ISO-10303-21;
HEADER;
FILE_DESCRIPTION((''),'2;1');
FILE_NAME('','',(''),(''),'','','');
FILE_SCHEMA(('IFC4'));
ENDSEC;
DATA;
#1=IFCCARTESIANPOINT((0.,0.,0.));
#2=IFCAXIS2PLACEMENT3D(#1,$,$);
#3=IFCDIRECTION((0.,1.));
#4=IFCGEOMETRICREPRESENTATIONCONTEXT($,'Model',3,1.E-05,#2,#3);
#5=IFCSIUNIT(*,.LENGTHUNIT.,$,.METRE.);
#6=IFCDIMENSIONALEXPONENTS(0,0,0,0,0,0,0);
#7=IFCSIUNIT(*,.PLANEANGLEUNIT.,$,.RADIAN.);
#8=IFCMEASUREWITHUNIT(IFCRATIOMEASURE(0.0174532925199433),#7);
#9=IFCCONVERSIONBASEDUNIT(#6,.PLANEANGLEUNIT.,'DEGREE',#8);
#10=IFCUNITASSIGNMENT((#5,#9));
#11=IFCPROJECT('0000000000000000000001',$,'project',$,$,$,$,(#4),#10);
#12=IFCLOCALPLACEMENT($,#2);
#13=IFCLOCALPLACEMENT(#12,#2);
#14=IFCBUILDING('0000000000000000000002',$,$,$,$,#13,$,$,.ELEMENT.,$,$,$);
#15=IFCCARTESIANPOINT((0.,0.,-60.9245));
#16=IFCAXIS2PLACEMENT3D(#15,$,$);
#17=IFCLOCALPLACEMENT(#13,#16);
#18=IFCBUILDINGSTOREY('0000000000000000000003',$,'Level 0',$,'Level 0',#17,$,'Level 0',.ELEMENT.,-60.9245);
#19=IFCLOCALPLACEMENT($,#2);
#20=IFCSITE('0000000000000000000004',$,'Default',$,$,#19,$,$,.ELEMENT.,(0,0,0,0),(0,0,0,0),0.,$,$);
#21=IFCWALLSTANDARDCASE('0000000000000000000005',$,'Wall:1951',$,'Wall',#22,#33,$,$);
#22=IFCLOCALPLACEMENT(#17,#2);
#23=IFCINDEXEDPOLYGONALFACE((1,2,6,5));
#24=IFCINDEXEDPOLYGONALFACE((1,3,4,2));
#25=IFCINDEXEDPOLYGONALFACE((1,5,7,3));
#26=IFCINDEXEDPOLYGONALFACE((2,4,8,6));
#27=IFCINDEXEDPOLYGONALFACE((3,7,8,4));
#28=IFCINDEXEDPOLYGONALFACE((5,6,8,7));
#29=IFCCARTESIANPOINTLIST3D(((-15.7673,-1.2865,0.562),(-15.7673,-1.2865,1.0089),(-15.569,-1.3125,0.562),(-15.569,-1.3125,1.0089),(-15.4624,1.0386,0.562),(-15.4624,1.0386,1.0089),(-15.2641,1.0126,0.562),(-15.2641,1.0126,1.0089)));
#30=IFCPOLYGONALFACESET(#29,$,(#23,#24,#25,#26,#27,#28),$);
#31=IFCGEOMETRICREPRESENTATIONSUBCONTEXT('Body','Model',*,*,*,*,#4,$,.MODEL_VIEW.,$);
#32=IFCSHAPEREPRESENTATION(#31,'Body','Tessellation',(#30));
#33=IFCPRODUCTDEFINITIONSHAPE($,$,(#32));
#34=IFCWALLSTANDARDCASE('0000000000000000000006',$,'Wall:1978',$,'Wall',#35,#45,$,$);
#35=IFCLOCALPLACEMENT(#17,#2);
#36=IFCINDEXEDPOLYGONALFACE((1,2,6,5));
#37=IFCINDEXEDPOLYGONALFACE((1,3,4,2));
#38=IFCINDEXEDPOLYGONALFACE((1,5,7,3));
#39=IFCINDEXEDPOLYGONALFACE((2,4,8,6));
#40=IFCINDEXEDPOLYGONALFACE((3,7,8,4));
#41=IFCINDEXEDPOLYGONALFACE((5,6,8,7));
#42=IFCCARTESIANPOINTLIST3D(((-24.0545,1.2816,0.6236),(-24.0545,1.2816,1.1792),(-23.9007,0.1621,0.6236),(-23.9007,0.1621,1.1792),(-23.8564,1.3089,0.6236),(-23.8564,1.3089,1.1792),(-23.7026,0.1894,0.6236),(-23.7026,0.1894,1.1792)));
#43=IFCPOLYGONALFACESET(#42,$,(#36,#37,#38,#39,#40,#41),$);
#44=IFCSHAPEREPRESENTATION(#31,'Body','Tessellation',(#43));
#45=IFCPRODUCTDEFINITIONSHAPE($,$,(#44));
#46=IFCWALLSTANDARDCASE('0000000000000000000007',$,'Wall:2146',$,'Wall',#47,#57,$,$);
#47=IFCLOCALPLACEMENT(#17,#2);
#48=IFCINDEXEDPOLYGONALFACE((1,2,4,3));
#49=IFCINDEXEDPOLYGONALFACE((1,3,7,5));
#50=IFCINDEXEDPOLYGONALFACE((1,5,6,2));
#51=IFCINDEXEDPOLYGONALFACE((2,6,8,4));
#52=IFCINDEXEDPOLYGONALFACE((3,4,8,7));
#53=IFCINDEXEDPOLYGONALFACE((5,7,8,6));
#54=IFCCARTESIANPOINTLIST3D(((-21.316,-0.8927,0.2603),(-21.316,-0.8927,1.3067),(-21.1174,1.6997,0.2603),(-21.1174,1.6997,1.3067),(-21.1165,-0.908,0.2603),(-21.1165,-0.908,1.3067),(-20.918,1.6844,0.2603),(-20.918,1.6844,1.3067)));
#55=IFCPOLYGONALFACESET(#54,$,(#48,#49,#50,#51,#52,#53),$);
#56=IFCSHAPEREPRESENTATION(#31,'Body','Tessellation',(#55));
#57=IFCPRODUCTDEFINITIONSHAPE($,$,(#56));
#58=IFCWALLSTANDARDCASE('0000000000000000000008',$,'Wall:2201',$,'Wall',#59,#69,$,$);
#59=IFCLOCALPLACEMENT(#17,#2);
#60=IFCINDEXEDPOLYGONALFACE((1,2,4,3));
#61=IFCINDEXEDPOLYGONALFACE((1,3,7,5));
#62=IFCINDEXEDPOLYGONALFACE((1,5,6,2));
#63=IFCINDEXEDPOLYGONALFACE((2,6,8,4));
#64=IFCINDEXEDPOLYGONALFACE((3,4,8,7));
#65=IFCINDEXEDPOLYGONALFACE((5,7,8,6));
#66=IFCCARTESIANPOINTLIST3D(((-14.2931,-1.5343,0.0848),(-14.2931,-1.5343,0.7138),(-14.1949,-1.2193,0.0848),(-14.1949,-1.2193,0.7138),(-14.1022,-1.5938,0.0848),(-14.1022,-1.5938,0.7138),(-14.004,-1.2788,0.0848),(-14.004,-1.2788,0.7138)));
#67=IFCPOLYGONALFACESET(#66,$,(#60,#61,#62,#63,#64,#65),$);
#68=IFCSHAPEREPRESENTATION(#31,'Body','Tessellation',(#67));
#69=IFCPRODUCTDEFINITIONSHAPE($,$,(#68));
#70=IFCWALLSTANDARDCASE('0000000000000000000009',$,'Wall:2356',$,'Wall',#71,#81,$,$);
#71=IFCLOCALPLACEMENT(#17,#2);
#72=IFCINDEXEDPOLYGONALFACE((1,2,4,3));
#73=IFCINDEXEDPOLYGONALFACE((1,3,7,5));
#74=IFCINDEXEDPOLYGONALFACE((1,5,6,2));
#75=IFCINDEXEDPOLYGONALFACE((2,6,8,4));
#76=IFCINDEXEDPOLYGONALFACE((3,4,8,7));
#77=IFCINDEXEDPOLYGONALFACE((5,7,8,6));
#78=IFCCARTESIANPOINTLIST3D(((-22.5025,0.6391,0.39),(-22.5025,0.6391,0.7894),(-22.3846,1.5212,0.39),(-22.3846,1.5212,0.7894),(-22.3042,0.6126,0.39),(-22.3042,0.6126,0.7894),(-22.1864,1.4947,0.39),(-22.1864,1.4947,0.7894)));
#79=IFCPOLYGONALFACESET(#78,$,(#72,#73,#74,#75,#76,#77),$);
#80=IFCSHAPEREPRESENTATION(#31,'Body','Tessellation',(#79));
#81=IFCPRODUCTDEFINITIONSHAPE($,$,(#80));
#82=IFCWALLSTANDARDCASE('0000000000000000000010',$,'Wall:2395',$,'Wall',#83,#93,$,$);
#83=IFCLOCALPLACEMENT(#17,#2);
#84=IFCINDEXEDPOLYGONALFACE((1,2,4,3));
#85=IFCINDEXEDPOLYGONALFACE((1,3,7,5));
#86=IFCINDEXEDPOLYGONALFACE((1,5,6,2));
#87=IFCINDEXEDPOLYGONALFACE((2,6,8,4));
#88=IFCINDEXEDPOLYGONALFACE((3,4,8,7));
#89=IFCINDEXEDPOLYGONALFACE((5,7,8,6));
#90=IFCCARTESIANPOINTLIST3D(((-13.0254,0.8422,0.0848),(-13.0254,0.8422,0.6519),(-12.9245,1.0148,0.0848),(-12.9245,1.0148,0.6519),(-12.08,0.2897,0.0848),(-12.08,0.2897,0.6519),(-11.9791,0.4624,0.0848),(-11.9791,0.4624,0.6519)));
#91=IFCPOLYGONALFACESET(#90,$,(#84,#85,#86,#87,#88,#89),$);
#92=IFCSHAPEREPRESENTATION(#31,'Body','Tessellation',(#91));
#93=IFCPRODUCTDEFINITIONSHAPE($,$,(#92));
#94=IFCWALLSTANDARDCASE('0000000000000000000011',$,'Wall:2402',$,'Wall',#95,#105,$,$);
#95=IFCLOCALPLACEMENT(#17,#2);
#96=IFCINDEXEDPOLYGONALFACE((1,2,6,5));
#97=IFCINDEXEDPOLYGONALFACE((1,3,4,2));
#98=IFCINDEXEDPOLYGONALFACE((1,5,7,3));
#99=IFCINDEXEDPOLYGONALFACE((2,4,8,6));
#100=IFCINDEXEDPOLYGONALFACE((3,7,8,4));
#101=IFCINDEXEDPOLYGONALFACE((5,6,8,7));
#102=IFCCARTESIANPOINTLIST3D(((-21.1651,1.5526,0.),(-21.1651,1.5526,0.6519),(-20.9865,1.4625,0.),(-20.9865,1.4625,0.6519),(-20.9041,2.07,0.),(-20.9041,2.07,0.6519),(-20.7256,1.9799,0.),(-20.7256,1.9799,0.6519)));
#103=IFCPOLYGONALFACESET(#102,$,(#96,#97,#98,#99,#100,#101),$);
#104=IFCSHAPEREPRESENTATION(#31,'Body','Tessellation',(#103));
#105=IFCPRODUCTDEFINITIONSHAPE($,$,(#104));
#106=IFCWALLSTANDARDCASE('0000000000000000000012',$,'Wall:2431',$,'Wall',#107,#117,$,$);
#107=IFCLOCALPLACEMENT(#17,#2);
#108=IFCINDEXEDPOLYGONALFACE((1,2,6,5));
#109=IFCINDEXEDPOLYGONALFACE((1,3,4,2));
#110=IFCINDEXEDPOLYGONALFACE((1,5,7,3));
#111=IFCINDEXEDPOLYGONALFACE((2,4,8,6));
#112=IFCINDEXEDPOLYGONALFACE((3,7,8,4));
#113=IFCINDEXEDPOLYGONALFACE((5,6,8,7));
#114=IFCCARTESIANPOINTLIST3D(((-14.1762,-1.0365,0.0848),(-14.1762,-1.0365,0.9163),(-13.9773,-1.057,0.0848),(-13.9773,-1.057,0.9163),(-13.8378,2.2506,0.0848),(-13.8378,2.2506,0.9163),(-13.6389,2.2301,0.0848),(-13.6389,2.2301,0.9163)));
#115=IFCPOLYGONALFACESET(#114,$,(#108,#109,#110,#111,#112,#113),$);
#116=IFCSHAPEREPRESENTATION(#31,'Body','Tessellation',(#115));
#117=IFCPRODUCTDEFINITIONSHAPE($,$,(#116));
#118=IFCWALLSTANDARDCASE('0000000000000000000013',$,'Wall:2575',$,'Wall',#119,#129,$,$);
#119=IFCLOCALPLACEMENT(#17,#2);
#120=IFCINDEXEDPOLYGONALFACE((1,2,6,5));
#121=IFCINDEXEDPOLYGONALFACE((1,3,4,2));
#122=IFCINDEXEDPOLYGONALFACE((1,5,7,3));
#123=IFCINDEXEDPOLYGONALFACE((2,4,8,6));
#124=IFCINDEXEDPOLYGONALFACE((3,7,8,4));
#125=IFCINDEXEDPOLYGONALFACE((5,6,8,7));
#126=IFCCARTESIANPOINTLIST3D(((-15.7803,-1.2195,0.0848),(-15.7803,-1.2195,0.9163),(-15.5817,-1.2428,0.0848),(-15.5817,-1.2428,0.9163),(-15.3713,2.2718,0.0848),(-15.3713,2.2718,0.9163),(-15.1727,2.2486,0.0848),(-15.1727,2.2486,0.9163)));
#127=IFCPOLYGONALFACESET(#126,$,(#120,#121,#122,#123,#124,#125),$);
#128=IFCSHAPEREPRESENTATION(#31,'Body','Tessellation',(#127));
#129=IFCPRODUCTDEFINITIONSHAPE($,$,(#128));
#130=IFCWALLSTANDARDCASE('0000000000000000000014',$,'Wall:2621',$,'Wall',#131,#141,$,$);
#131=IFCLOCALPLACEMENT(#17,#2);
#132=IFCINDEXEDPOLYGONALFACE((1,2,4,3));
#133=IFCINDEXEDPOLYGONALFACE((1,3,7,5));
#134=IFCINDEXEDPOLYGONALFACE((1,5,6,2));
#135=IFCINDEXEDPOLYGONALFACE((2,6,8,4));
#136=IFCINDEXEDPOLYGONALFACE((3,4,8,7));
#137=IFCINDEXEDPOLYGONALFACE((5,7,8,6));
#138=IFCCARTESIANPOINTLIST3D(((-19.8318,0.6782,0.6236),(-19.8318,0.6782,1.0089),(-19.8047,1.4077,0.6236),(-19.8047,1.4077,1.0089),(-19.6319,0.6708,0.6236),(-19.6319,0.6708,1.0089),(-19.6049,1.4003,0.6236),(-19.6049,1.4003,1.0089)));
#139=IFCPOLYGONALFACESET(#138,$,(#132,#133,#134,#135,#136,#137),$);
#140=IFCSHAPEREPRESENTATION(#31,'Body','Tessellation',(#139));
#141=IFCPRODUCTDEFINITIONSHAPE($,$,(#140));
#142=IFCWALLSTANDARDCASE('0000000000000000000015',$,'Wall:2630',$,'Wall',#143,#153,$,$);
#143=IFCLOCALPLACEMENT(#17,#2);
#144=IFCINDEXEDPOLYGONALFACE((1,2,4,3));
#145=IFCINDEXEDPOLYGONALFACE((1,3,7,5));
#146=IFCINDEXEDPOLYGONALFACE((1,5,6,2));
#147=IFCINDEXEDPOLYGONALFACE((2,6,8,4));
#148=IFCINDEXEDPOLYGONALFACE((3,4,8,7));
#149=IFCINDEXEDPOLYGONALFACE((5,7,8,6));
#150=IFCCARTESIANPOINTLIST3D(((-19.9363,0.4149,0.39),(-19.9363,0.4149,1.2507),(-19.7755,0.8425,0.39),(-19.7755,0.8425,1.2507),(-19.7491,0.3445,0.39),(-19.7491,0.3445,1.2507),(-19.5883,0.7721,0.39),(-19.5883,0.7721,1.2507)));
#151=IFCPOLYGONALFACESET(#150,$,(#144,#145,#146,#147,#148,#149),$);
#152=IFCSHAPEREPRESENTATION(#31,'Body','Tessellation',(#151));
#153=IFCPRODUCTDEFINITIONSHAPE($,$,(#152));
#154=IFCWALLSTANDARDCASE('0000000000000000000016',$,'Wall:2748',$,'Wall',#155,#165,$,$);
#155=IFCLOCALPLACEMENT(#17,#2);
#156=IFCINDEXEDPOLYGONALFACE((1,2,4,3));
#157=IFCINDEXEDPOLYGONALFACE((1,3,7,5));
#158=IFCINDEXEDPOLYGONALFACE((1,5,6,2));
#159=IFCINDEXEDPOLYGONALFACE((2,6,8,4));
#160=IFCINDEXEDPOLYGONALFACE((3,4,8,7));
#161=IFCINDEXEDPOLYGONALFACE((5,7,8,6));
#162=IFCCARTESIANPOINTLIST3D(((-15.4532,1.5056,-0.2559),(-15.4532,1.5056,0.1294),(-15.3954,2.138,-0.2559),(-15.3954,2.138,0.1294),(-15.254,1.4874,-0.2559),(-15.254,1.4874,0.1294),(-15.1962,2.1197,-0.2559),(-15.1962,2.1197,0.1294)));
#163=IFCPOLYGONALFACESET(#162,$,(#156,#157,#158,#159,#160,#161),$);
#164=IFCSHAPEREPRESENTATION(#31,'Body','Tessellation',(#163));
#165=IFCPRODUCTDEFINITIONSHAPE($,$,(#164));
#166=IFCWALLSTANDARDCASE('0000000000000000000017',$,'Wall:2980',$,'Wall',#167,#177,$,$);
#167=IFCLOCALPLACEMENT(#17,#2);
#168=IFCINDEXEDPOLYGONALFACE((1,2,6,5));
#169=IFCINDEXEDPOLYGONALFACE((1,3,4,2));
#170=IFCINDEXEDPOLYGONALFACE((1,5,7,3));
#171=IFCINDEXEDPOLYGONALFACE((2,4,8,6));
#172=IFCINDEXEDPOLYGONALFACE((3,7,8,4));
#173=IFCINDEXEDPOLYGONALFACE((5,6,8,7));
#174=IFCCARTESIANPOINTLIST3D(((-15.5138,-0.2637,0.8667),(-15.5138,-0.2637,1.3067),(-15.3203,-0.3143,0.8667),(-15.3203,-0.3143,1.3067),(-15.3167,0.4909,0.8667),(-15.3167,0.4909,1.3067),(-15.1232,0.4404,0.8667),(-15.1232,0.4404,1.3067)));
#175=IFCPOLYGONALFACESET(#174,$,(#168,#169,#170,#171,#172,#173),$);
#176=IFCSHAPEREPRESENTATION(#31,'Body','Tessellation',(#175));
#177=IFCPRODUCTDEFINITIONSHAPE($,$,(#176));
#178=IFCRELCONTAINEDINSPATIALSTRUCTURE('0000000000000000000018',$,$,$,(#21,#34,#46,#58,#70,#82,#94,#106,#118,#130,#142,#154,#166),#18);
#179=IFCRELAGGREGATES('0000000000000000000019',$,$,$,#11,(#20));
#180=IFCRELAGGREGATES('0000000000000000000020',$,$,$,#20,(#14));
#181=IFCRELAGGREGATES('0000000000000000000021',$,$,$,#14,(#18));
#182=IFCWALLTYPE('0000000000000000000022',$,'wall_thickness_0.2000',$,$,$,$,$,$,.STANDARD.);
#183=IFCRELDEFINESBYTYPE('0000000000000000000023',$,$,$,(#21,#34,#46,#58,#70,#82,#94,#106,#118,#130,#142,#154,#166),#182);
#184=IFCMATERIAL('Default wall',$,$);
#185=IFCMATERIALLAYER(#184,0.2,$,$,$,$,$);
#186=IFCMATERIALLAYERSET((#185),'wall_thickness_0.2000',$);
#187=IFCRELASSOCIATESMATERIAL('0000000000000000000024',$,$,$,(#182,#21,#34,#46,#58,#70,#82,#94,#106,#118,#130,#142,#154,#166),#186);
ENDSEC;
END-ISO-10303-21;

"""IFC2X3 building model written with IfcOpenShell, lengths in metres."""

from ifc_helpers import new_model, entity, si_unit, converted_unit, direction, frame, origin, place, context, subcontext, project, spatial, polyline, outline, extrude, material, layer, layer_set, layer_usage, type_object, element, save


model = new_model("IFC2X3")

# Units and contexts
model_context = context("Model", 3, precision=1e-05, world=origin(), true_north=direction((0.0, 1.0)))
body_context = subcontext(model_context, "Body", "Model", "MODEL_VIEW")
ifc_project = project(units=[si_unit("LENGTHUNIT", "METRE"), converted_unit("PLANEANGLEUNIT", "DEGREE", entity("IfcRatioMeasure", 0.0174532925199433), si_unit("PLANEANGLEUNIT", "RADIAN"), dimensions=[0, 0, 0, 0, 0, 0, 0])], contexts=[model_context])

# Site, building, storey
site_placement = place(None, origin())
site = spatial("IfcSite", under=ifc_project, at=site_placement, Name="Default", CompositionType="ELEMENT", RefLatitude=(0, 0, 0, 0), RefLongitude=(0, 0, 0, 0), RefElevation=0.0)
placement_1 = place(None, origin())
building_placement = place(placement_1, origin())
building = spatial("IfcBuilding", under=site, at=building_placement, CompositionType="ELEMENT")
storey_placement = place(building_placement, frame((0.0, 0.0, -60.9245)))
storey = spatial("IfcBuildingStorey", under=building, at=storey_placement, Name="Level 0", ObjectType="Level 0", LongName="Level 0", CompositionType="ELEMENT", Elevation=-60.9245)

# Walls
ifc_material = material(Name="Default wall")
ifc_layer = layer(ifc_material, 0.2)
ifc_layer_set = layer_set([ifc_layer], Name="wall_thickness_0.2000")
ifc_layer_usage = layer_usage(ifc_layer_set, "AXIS2", "POSITIVE", -0.1)
wall_type = type_object("IfcWallType", Name="wall_thickness_0.2000", PredefinedType="STANDARD", material=ifc_layer_set)
placement_2 = place(building_placement, frame((0.0, 0.0, -60.3625)))
wall_1_placement = place(placement_2, frame((-15.6682, -1.2995, 0.0), z_axis=(0.0, 0.0, 1.0), x_axis=(0.130025, 0.991511, 0.0)))
element("IfcWallStandardCase", 1, at=wall_1_placement, inside=storey, type_object=wall_type, material=ifc_layer_usage, Name="Wall:1951", ObjectType="Wall", context=body_context, shape_type="SweptSolid", body=[
    extrude(outline(polyline([(2.345, -0.1), (2.345, 0.1), (0.0, 0.1), (0.0, -0.1), (2.345, -0.1)])), origin(), (0.0, 0.0, 1.0), 0.447),
])
placement_3 = place(building_placement, frame((0.0, 0.0, -60.3009)))
wall_2_placement = place(placement_3, frame((-23.9554, 1.2952, 0.0), z_axis=(0.0, 0.0, 1.0), x_axis=(0.13611, -0.990694, 0.0)))
element("IfcWallStandardCase", 2, at=wall_2_placement, inside=storey, type_object=wall_type, material=ifc_layer_usage, Name="Wall:1978", ObjectType="Wall", context=body_context, shape_type="SweptSolid", body=[
    extrude(outline(polyline([(1.13, -0.1), (1.13, 0.1), (0.0, 0.1), (0.0, -0.1), (1.13, -0.1)])), origin(), (0.0, 0.0, 1.0), 0.5556),
])
placement_4 = place(building_placement, frame((0.0, 0.0, -60.6642)))
wall_3_placement = place(placement_4, frame((-21.2162, -0.9004, 0.0), z_axis=(0.0, 0.0, 1.0), x_axis=(0.076374, 0.997079, 0.0)))
element("IfcWallStandardCase", 3, at=wall_3_placement, inside=storey, type_object=wall_type, material=ifc_layer_usage, Name="Wall:2146", ObjectType="Wall", context=body_context, shape_type="SweptSolid", body=[
    extrude(outline(polyline([(2.6, -0.1), (2.6, 0.1), (0.0, 0.1), (0.0, -0.1), (2.6, -0.1)])), origin(), (0.0, 0.0, 1.0), 1.0464),
])
placement_5 = place(building_placement, frame((0.0, 0.0, -60.8397)))
wall_4_placement = place(placement_5, frame((-14.0995, -1.249, 0.0), z_axis=(0.0, 0.0, 1.0), x_axis=(-0.297497, -0.954723, 0.0)))
element("IfcWallStandardCase", 4, at=wall_4_placement, inside=storey, type_object=wall_type, material=ifc_layer_usage, Name="Wall:2201", ObjectType="Wall", context=body_context, shape_type="SweptSolid", body=[
    extrude(outline(polyline([(0.33, -0.1), (0.33, 0.1), (0.0, 0.1), (0.0, -0.1), (0.33, -0.1)])), origin(), (0.0, 0.0, 1.0), 0.629),
])
placement_6 = place(building_placement, frame((0.0, 0.0, -60.5345)))
wall_5_placement = place(placement_6, frame((-22.4033, 0.6258, 0.0), z_axis=(0.0, 0.0, 1.0), x_axis=(0.13243, 0.991192, 0.0)))
element("IfcWallStandardCase", 5, at=wall_5_placement, inside=storey, type_object=wall_type, material=ifc_layer_usage, Name="Wall:2356", ObjectType="Wall", context=body_context, shape_type="SweptSolid", body=[
    extrude(outline(polyline([(0.89, -0.1), (0.89, 0.1), (0.0, 0.1), (0.0, -0.1), (0.89, -0.1)])), origin(), (0.0, 0.0, 1.0), 0.3994),
])
placement_7 = place(building_placement, frame((0.0, 0.0, -60.8397)))
wall_6_placement = place(placement_7, frame((-12.975, 0.9285, 0.0), z_axis=(0.0, 0.0, 1.0), x_axis=(0.863395, -0.504529, 0.0)))
element("IfcWallStandardCase", 6, at=wall_6_placement, inside=storey, type_object=wall_type, material=ifc_layer_usage, Name="Wall:2395", ObjectType="Wall", context=body_context, shape_type="SweptSolid", body=[
    extrude(outline(polyline([(1.095, -0.1), (1.095, 0.1), (0.0, 0.1), (0.0, -0.1), (1.095, -0.1)])), origin(), (0.0, 0.0, 1.0), 0.5671),
])
wall_7_placement = place(storey_placement, frame((-21.0758, 1.5075, 0.0), z_axis=(0.0, 0.0, 1.0), x_axis=(0.450372, 0.892841, 0.0)))
element("IfcWallStandardCase", 7, at=wall_7_placement, inside=storey, type_object=wall_type, material=ifc_layer_usage, Name="Wall:2402", ObjectType="Wall", context=body_context, shape_type="SweptSolid", body=[
    extrude(outline(polyline([(0.5795, -0.1), (0.5795, 0.1), (0.0, 0.1), (0.0, -0.1), (0.5795, -0.1)])), origin(), (0.0, 0.0, 1.0), 0.6519),
])
placement_8 = place(building_placement, frame((0.0, 0.0, -60.8397)))
wall_8_placement = place(placement_8, frame((-14.0768, -1.0467, 0.0), z_axis=(0.0, 0.0, 1.0), x_axis=(0.102409, 0.994742, 0.0)))
element("IfcWallStandardCase", 8, at=wall_8_placement, inside=storey, type_object=wall_type, material=ifc_layer_usage, Name="Wall:2431", ObjectType="Wall", context=body_context, shape_type="SweptSolid", body=[
    extrude(outline(polyline([(3.3045, -0.1), (3.3045, 0.1), (0.0, 0.1), (0.0, -0.1), (3.3045, -0.1)])), origin(), (0.0, 0.0, 1.0), 0.8315),
])
placement_9 = place(building_placement, frame((0.0, 0.0, -60.8397)))
wall_9_placement = place(placement_9, frame((-15.681, -1.2312, 0.0), z_axis=(0.0, 0.0, 1.0), x_axis=(0.11635, 0.993208, 0.0)))
element("IfcWallStandardCase", 9, at=wall_9_placement, inside=storey, type_object=wall_type, material=ifc_layer_usage, Name="Wall:2575", ObjectType="Wall", context=body_context, shape_type="SweptSolid", body=[
    extrude(outline(polyline([(3.5153, -0.1), (3.5153, 0.1), (0.0, 0.1), (0.0, -0.1), (3.5153, -0.1)])), origin(), (0.0, 0.0, 1.0), 0.8315),
])
placement_10 = place(building_placement, frame((0.0, 0.0, -60.3009)))
wall_10_placement = place(placement_10, frame((-19.7319, 0.6745, 0.0), z_axis=(0.0, 0.0, 1.0), x_axis=(0.037105, 0.999311, 0.0)))
element("IfcWallStandardCase", 10, at=wall_10_placement, inside=storey, type_object=wall_type, material=ifc_layer_usage, Name="Wall:2621", ObjectType="Wall", context=body_context, shape_type="SweptSolid", body=[
    extrude(outline(polyline([(0.73, -0.1), (0.73, 0.1), (0.0, 0.1), (0.0, -0.1), (0.73, -0.1)])), origin(), (0.0, 0.0, 1.0), 0.3853),
])
placement_11 = place(building_placement, frame((0.0, 0.0, -60.5345)))
wall_11_placement = place(placement_11, frame((-19.8427, 0.3797, 0.0), z_axis=(0.0, 0.0, 1.0), x_axis=(0.351973, 0.93601, 0.0)))
element("IfcWallStandardCase", 11, at=wall_11_placement, inside=storey, type_object=wall_type, material=ifc_layer_usage, Name="Wall:2630", ObjectType="Wall", context=body_context, shape_type="SweptSolid", body=[
    extrude(outline(polyline([(0.4569, -0.1), (0.4569, 0.1), (0.0, 0.1), (0.0, -0.1), (0.4569, -0.1)])), origin(), (0.0, 0.0, 1.0), 0.8607),
])
placement_12 = place(building_placement, frame((0.0, 0.0, -61.1804)))
wall_12_placement = place(placement_12, frame((-15.3536, 1.4965, 0.0), z_axis=(0.0, 0.0, 1.0), x_axis=(0.091102, 0.995842, 0.0)))
element("IfcWallStandardCase", 12, at=wall_12_placement, inside=storey, type_object=wall_type, material=ifc_layer_usage, Name="Wall:2748", ObjectType="Wall", context=body_context, shape_type="SweptSolid", body=[
    extrude(outline(polyline([(0.635, -0.1), (0.635, 0.1), (0.0, 0.1), (0.0, -0.1), (0.635, -0.1)])), origin(), (0.0, 0.0, 1.0), 0.3853),
])
placement_13 = place(building_placement, frame((0.0, 0.0, -60.0578)))
wall_13_placement = place(placement_13, frame((-15.4171, -0.289, 0.0), z_axis=(0.0, 0.0, 1.0), x_axis=(0.252756, 0.96753, 0.0)))
element("IfcWallStandardCase", 13, at=wall_13_placement, inside=storey, type_object=wall_type, material=ifc_layer_usage, Name="Wall:2980", ObjectType="Wall", context=body_context, shape_type="SweptSolid", body=[
    extrude(outline(polyline([(0.78, -0.1), (0.78, 0.1), (0.0, 0.1), (0.0, -0.1), (0.78, -0.1)])), origin(), (0.0, 0.0, 1.0), 0.44),
])

save(model, "model.ifc")
